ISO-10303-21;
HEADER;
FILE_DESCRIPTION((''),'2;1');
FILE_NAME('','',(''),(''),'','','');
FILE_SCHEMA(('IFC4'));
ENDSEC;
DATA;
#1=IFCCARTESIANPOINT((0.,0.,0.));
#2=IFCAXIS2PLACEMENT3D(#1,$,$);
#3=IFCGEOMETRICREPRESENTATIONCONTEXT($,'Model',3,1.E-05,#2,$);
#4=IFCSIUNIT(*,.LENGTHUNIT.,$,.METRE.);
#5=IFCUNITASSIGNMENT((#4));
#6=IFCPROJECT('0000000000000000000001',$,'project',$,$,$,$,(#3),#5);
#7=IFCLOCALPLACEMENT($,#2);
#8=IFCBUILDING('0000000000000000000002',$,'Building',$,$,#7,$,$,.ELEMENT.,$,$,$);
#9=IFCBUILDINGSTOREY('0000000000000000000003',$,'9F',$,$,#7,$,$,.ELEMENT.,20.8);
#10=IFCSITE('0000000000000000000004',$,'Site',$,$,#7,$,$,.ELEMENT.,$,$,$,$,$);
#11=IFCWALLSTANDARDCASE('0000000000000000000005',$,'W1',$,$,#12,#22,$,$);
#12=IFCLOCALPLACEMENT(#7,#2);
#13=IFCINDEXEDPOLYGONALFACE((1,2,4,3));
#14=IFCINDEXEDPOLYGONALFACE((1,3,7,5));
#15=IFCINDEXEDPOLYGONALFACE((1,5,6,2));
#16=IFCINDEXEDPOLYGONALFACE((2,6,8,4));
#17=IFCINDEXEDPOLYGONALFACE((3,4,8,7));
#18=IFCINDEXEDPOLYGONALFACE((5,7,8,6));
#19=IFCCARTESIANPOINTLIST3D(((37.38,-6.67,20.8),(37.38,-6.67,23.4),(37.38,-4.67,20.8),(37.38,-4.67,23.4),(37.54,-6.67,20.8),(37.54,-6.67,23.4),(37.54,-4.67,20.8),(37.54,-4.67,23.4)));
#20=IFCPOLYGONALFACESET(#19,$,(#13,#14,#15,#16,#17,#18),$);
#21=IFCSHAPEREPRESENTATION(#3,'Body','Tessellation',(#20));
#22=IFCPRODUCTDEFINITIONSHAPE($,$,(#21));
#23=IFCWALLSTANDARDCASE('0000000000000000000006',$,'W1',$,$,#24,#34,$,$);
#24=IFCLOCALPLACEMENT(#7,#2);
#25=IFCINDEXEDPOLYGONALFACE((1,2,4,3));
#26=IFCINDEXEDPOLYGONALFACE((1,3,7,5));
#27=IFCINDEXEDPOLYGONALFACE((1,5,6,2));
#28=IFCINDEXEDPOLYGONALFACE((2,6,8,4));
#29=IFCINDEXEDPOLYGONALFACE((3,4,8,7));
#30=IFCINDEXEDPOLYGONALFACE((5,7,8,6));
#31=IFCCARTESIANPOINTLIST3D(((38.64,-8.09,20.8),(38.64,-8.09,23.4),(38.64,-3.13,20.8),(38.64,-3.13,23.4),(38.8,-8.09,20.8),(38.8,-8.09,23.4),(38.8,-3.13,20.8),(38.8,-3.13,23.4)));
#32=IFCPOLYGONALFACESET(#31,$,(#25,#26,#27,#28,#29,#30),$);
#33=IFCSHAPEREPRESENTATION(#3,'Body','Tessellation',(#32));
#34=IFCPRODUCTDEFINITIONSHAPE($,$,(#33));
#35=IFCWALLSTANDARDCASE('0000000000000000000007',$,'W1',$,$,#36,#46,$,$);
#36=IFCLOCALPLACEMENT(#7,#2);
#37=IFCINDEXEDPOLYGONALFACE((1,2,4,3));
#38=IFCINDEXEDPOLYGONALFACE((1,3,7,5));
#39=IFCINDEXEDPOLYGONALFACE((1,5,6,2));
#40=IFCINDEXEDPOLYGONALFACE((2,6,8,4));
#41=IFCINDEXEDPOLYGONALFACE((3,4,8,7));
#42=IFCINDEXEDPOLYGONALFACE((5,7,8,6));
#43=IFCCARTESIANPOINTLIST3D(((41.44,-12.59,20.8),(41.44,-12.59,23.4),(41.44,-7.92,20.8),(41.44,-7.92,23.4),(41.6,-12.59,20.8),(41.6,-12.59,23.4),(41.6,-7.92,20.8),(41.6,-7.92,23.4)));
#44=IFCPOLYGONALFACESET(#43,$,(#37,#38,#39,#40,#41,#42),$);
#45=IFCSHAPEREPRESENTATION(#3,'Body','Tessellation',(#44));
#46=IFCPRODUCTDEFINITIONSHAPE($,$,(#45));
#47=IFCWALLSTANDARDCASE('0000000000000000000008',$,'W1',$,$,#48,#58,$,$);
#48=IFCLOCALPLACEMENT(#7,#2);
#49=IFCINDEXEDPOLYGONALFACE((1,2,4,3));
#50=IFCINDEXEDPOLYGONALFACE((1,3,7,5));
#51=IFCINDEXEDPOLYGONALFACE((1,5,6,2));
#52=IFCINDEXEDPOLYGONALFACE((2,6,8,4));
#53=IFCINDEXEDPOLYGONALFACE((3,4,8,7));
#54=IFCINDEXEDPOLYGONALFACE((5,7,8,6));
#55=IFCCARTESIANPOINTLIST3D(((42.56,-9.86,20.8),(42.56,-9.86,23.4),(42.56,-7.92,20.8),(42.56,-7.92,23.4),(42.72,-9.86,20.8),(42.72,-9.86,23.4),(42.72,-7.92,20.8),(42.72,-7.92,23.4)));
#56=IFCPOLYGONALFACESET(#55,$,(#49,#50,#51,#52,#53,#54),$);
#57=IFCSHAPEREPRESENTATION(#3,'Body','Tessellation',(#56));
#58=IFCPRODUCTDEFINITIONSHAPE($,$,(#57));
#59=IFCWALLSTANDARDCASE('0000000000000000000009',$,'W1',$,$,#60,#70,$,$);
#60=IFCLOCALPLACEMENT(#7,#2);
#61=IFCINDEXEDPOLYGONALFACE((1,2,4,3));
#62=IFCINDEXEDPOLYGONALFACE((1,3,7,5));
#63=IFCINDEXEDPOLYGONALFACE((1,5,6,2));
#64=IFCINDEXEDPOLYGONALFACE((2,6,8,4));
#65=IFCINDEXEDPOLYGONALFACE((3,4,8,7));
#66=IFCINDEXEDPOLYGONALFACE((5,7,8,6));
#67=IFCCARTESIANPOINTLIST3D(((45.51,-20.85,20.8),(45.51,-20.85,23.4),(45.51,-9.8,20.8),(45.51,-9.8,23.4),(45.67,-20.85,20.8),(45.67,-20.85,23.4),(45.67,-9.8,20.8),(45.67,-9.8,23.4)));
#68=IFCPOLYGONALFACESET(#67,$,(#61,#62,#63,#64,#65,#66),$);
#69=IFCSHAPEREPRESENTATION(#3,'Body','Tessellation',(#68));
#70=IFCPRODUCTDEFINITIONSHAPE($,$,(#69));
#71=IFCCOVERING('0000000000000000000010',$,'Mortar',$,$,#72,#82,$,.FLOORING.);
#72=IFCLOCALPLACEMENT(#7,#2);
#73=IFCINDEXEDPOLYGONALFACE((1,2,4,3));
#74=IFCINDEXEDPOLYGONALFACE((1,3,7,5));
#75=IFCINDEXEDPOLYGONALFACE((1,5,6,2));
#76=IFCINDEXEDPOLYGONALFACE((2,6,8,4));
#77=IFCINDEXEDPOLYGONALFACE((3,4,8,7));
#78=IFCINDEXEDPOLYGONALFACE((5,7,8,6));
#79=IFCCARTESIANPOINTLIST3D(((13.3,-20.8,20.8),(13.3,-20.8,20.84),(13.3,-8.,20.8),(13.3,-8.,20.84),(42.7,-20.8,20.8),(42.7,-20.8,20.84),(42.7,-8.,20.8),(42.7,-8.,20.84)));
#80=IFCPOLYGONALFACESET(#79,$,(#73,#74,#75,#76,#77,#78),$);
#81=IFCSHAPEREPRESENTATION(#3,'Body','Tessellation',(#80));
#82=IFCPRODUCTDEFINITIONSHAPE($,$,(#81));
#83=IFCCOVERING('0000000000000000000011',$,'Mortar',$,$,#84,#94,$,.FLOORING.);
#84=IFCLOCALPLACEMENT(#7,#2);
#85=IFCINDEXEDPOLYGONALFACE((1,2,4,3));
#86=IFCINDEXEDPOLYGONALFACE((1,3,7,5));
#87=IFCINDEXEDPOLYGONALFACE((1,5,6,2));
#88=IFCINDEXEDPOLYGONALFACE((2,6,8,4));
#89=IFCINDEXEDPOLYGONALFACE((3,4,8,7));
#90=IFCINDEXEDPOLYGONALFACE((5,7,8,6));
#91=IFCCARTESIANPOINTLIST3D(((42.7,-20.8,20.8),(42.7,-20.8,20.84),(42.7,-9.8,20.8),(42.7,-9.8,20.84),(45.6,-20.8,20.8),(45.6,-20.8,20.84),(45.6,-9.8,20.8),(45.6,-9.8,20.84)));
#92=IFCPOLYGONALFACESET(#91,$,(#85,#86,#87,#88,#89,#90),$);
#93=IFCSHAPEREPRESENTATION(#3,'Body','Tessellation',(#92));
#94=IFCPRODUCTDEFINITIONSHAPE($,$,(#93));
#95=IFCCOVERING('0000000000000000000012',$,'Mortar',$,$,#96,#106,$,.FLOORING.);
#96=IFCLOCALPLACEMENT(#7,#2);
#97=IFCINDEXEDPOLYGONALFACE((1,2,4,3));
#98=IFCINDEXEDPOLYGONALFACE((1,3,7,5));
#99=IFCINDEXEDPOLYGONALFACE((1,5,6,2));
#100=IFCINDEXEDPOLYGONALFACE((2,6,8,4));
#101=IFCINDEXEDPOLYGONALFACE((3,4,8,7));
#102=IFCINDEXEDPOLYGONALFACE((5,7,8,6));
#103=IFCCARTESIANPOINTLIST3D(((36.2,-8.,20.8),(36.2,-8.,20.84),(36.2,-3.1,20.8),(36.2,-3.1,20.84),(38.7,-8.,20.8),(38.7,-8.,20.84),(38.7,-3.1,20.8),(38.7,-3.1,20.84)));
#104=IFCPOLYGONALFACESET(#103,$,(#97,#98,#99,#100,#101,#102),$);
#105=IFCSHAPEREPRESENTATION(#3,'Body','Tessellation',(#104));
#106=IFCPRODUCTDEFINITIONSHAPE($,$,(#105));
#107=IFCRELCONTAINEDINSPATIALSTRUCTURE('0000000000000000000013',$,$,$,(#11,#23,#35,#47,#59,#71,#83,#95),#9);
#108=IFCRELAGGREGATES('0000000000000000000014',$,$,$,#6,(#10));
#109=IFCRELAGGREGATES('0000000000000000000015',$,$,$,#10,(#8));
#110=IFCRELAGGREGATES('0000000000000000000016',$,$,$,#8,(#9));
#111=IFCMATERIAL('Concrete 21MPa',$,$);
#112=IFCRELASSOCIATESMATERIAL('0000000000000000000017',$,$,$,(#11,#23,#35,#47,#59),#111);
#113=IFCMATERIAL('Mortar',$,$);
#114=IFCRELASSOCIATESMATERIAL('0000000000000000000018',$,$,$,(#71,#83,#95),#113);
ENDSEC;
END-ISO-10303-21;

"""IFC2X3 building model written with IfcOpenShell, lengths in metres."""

from ifc_helpers import new_model, si_unit, frame, origin, origin_2d, place, context, project, spatial, rectangle, extrude, material, element, save


model = new_model("IFC2X3")

# Units and contexts
model_context = context("Model", 3, precision=1e-05, world=origin())
ifc_project = project(units=[si_unit("LENGTHUNIT", "METRE")], contexts=[model_context])

# Site, building, storey
placement = place(None, origin())
site = spatial("IfcSite", under=ifc_project, at=placement, Name="Site", CompositionType="ELEMENT")
building = spatial("IfcBuilding", under=site, at=placement, Name="Building", CompositionType="ELEMENT")
storey = spatial("IfcBuildingStorey", under=building, at=placement, Name="9F", CompositionType="ELEMENT", Elevation=20.8)

# Shared definitions
ifc_material_1 = material(Name="Concrete 21MPa")

# Walls
wall_1_placement = place(None, frame((37.46, -5.67, 20.8)))
element("IfcWallStandardCase", 1, at=wall_1_placement, inside=storey, material=ifc_material_1, Name="W1", context=model_context, shape_type="SweptSolid", body=[
    extrude(rectangle(XDim=0.16, YDim=2.0, at=origin_2d()), origin(), (0.0, 0.0, 1.0), 2.6),
])
wall_2_placement = place(None, frame((38.72, -5.61, 20.8)))
element("IfcWallStandardCase", 2, at=wall_2_placement, inside=storey, material=ifc_material_1, Name="W1", context=model_context, shape_type="SweptSolid", body=[
    extrude(rectangle(XDim=0.16, YDim=4.96, at=origin_2d()), origin(), (0.0, 0.0, 1.0), 2.6),
])
wall_3_placement = place(None, frame((41.52, -10.255, 20.8)))
element("IfcWallStandardCase", 3, at=wall_3_placement, inside=storey, material=ifc_material_1, Name="W1", context=model_context, shape_type="SweptSolid", body=[
    extrude(rectangle(XDim=0.16, YDim=4.67, at=origin_2d()), origin(), (0.0, 0.0, 1.0), 2.6),
])
wall_4_placement = place(None, frame((42.64, -8.89, 20.8)))
element("IfcWallStandardCase", 4, at=wall_4_placement, inside=storey, material=ifc_material_1, Name="W1", context=model_context, shape_type="SweptSolid", body=[
    extrude(rectangle(XDim=0.16, YDim=1.94, at=origin_2d()), origin(), (0.0, 0.0, 1.0), 2.6),
])
wall_5_placement = place(None, frame((45.59, -15.325, 20.8)))
element("IfcWallStandardCase", 5, at=wall_5_placement, inside=storey, material=ifc_material_1, Name="W1", context=model_context, shape_type="SweptSolid", body=[
    extrude(rectangle(XDim=0.16, YDim=11.05, at=origin_2d()), origin(), (0.0, 0.0, 1.0), 2.6),
])

# Coverings
ifc_material_2 = material(Name="Mortar")
covering_1_placement = place(None, frame((28.0, -14.4, 20.8)))
element("IfcCovering", 6, at=covering_1_placement, inside=storey, material=ifc_material_2, Name="Mortar", PredefinedType="FLOORING", context=model_context, shape_type="SweptSolid", body=[
    extrude(rectangle(XDim=29.4, YDim=12.8, at=origin_2d()), origin(), (0.0, 0.0, 1.0), 0.04),
])
covering_2_placement = place(None, frame((44.15, -15.3, 20.8)))
element("IfcCovering", 7, at=covering_2_placement, inside=storey, material=ifc_material_2, Name="Mortar", PredefinedType="FLOORING", context=model_context, shape_type="SweptSolid", body=[
    extrude(rectangle(XDim=2.9, YDim=11.0, at=origin_2d()), origin(), (0.0, 0.0, 1.0), 0.04),
])
covering_3_placement = place(None, frame((37.45, -5.55, 20.8)))
element("IfcCovering", 8, at=covering_3_placement, inside=storey, material=ifc_material_2, Name="Mortar", PredefinedType="FLOORING", context=model_context, shape_type="SweptSolid", body=[
    extrude(rectangle(XDim=2.5, YDim=4.9, at=origin_2d()), origin(), (0.0, 0.0, 1.0), 0.04),
])

save(model, "model.ifc")
